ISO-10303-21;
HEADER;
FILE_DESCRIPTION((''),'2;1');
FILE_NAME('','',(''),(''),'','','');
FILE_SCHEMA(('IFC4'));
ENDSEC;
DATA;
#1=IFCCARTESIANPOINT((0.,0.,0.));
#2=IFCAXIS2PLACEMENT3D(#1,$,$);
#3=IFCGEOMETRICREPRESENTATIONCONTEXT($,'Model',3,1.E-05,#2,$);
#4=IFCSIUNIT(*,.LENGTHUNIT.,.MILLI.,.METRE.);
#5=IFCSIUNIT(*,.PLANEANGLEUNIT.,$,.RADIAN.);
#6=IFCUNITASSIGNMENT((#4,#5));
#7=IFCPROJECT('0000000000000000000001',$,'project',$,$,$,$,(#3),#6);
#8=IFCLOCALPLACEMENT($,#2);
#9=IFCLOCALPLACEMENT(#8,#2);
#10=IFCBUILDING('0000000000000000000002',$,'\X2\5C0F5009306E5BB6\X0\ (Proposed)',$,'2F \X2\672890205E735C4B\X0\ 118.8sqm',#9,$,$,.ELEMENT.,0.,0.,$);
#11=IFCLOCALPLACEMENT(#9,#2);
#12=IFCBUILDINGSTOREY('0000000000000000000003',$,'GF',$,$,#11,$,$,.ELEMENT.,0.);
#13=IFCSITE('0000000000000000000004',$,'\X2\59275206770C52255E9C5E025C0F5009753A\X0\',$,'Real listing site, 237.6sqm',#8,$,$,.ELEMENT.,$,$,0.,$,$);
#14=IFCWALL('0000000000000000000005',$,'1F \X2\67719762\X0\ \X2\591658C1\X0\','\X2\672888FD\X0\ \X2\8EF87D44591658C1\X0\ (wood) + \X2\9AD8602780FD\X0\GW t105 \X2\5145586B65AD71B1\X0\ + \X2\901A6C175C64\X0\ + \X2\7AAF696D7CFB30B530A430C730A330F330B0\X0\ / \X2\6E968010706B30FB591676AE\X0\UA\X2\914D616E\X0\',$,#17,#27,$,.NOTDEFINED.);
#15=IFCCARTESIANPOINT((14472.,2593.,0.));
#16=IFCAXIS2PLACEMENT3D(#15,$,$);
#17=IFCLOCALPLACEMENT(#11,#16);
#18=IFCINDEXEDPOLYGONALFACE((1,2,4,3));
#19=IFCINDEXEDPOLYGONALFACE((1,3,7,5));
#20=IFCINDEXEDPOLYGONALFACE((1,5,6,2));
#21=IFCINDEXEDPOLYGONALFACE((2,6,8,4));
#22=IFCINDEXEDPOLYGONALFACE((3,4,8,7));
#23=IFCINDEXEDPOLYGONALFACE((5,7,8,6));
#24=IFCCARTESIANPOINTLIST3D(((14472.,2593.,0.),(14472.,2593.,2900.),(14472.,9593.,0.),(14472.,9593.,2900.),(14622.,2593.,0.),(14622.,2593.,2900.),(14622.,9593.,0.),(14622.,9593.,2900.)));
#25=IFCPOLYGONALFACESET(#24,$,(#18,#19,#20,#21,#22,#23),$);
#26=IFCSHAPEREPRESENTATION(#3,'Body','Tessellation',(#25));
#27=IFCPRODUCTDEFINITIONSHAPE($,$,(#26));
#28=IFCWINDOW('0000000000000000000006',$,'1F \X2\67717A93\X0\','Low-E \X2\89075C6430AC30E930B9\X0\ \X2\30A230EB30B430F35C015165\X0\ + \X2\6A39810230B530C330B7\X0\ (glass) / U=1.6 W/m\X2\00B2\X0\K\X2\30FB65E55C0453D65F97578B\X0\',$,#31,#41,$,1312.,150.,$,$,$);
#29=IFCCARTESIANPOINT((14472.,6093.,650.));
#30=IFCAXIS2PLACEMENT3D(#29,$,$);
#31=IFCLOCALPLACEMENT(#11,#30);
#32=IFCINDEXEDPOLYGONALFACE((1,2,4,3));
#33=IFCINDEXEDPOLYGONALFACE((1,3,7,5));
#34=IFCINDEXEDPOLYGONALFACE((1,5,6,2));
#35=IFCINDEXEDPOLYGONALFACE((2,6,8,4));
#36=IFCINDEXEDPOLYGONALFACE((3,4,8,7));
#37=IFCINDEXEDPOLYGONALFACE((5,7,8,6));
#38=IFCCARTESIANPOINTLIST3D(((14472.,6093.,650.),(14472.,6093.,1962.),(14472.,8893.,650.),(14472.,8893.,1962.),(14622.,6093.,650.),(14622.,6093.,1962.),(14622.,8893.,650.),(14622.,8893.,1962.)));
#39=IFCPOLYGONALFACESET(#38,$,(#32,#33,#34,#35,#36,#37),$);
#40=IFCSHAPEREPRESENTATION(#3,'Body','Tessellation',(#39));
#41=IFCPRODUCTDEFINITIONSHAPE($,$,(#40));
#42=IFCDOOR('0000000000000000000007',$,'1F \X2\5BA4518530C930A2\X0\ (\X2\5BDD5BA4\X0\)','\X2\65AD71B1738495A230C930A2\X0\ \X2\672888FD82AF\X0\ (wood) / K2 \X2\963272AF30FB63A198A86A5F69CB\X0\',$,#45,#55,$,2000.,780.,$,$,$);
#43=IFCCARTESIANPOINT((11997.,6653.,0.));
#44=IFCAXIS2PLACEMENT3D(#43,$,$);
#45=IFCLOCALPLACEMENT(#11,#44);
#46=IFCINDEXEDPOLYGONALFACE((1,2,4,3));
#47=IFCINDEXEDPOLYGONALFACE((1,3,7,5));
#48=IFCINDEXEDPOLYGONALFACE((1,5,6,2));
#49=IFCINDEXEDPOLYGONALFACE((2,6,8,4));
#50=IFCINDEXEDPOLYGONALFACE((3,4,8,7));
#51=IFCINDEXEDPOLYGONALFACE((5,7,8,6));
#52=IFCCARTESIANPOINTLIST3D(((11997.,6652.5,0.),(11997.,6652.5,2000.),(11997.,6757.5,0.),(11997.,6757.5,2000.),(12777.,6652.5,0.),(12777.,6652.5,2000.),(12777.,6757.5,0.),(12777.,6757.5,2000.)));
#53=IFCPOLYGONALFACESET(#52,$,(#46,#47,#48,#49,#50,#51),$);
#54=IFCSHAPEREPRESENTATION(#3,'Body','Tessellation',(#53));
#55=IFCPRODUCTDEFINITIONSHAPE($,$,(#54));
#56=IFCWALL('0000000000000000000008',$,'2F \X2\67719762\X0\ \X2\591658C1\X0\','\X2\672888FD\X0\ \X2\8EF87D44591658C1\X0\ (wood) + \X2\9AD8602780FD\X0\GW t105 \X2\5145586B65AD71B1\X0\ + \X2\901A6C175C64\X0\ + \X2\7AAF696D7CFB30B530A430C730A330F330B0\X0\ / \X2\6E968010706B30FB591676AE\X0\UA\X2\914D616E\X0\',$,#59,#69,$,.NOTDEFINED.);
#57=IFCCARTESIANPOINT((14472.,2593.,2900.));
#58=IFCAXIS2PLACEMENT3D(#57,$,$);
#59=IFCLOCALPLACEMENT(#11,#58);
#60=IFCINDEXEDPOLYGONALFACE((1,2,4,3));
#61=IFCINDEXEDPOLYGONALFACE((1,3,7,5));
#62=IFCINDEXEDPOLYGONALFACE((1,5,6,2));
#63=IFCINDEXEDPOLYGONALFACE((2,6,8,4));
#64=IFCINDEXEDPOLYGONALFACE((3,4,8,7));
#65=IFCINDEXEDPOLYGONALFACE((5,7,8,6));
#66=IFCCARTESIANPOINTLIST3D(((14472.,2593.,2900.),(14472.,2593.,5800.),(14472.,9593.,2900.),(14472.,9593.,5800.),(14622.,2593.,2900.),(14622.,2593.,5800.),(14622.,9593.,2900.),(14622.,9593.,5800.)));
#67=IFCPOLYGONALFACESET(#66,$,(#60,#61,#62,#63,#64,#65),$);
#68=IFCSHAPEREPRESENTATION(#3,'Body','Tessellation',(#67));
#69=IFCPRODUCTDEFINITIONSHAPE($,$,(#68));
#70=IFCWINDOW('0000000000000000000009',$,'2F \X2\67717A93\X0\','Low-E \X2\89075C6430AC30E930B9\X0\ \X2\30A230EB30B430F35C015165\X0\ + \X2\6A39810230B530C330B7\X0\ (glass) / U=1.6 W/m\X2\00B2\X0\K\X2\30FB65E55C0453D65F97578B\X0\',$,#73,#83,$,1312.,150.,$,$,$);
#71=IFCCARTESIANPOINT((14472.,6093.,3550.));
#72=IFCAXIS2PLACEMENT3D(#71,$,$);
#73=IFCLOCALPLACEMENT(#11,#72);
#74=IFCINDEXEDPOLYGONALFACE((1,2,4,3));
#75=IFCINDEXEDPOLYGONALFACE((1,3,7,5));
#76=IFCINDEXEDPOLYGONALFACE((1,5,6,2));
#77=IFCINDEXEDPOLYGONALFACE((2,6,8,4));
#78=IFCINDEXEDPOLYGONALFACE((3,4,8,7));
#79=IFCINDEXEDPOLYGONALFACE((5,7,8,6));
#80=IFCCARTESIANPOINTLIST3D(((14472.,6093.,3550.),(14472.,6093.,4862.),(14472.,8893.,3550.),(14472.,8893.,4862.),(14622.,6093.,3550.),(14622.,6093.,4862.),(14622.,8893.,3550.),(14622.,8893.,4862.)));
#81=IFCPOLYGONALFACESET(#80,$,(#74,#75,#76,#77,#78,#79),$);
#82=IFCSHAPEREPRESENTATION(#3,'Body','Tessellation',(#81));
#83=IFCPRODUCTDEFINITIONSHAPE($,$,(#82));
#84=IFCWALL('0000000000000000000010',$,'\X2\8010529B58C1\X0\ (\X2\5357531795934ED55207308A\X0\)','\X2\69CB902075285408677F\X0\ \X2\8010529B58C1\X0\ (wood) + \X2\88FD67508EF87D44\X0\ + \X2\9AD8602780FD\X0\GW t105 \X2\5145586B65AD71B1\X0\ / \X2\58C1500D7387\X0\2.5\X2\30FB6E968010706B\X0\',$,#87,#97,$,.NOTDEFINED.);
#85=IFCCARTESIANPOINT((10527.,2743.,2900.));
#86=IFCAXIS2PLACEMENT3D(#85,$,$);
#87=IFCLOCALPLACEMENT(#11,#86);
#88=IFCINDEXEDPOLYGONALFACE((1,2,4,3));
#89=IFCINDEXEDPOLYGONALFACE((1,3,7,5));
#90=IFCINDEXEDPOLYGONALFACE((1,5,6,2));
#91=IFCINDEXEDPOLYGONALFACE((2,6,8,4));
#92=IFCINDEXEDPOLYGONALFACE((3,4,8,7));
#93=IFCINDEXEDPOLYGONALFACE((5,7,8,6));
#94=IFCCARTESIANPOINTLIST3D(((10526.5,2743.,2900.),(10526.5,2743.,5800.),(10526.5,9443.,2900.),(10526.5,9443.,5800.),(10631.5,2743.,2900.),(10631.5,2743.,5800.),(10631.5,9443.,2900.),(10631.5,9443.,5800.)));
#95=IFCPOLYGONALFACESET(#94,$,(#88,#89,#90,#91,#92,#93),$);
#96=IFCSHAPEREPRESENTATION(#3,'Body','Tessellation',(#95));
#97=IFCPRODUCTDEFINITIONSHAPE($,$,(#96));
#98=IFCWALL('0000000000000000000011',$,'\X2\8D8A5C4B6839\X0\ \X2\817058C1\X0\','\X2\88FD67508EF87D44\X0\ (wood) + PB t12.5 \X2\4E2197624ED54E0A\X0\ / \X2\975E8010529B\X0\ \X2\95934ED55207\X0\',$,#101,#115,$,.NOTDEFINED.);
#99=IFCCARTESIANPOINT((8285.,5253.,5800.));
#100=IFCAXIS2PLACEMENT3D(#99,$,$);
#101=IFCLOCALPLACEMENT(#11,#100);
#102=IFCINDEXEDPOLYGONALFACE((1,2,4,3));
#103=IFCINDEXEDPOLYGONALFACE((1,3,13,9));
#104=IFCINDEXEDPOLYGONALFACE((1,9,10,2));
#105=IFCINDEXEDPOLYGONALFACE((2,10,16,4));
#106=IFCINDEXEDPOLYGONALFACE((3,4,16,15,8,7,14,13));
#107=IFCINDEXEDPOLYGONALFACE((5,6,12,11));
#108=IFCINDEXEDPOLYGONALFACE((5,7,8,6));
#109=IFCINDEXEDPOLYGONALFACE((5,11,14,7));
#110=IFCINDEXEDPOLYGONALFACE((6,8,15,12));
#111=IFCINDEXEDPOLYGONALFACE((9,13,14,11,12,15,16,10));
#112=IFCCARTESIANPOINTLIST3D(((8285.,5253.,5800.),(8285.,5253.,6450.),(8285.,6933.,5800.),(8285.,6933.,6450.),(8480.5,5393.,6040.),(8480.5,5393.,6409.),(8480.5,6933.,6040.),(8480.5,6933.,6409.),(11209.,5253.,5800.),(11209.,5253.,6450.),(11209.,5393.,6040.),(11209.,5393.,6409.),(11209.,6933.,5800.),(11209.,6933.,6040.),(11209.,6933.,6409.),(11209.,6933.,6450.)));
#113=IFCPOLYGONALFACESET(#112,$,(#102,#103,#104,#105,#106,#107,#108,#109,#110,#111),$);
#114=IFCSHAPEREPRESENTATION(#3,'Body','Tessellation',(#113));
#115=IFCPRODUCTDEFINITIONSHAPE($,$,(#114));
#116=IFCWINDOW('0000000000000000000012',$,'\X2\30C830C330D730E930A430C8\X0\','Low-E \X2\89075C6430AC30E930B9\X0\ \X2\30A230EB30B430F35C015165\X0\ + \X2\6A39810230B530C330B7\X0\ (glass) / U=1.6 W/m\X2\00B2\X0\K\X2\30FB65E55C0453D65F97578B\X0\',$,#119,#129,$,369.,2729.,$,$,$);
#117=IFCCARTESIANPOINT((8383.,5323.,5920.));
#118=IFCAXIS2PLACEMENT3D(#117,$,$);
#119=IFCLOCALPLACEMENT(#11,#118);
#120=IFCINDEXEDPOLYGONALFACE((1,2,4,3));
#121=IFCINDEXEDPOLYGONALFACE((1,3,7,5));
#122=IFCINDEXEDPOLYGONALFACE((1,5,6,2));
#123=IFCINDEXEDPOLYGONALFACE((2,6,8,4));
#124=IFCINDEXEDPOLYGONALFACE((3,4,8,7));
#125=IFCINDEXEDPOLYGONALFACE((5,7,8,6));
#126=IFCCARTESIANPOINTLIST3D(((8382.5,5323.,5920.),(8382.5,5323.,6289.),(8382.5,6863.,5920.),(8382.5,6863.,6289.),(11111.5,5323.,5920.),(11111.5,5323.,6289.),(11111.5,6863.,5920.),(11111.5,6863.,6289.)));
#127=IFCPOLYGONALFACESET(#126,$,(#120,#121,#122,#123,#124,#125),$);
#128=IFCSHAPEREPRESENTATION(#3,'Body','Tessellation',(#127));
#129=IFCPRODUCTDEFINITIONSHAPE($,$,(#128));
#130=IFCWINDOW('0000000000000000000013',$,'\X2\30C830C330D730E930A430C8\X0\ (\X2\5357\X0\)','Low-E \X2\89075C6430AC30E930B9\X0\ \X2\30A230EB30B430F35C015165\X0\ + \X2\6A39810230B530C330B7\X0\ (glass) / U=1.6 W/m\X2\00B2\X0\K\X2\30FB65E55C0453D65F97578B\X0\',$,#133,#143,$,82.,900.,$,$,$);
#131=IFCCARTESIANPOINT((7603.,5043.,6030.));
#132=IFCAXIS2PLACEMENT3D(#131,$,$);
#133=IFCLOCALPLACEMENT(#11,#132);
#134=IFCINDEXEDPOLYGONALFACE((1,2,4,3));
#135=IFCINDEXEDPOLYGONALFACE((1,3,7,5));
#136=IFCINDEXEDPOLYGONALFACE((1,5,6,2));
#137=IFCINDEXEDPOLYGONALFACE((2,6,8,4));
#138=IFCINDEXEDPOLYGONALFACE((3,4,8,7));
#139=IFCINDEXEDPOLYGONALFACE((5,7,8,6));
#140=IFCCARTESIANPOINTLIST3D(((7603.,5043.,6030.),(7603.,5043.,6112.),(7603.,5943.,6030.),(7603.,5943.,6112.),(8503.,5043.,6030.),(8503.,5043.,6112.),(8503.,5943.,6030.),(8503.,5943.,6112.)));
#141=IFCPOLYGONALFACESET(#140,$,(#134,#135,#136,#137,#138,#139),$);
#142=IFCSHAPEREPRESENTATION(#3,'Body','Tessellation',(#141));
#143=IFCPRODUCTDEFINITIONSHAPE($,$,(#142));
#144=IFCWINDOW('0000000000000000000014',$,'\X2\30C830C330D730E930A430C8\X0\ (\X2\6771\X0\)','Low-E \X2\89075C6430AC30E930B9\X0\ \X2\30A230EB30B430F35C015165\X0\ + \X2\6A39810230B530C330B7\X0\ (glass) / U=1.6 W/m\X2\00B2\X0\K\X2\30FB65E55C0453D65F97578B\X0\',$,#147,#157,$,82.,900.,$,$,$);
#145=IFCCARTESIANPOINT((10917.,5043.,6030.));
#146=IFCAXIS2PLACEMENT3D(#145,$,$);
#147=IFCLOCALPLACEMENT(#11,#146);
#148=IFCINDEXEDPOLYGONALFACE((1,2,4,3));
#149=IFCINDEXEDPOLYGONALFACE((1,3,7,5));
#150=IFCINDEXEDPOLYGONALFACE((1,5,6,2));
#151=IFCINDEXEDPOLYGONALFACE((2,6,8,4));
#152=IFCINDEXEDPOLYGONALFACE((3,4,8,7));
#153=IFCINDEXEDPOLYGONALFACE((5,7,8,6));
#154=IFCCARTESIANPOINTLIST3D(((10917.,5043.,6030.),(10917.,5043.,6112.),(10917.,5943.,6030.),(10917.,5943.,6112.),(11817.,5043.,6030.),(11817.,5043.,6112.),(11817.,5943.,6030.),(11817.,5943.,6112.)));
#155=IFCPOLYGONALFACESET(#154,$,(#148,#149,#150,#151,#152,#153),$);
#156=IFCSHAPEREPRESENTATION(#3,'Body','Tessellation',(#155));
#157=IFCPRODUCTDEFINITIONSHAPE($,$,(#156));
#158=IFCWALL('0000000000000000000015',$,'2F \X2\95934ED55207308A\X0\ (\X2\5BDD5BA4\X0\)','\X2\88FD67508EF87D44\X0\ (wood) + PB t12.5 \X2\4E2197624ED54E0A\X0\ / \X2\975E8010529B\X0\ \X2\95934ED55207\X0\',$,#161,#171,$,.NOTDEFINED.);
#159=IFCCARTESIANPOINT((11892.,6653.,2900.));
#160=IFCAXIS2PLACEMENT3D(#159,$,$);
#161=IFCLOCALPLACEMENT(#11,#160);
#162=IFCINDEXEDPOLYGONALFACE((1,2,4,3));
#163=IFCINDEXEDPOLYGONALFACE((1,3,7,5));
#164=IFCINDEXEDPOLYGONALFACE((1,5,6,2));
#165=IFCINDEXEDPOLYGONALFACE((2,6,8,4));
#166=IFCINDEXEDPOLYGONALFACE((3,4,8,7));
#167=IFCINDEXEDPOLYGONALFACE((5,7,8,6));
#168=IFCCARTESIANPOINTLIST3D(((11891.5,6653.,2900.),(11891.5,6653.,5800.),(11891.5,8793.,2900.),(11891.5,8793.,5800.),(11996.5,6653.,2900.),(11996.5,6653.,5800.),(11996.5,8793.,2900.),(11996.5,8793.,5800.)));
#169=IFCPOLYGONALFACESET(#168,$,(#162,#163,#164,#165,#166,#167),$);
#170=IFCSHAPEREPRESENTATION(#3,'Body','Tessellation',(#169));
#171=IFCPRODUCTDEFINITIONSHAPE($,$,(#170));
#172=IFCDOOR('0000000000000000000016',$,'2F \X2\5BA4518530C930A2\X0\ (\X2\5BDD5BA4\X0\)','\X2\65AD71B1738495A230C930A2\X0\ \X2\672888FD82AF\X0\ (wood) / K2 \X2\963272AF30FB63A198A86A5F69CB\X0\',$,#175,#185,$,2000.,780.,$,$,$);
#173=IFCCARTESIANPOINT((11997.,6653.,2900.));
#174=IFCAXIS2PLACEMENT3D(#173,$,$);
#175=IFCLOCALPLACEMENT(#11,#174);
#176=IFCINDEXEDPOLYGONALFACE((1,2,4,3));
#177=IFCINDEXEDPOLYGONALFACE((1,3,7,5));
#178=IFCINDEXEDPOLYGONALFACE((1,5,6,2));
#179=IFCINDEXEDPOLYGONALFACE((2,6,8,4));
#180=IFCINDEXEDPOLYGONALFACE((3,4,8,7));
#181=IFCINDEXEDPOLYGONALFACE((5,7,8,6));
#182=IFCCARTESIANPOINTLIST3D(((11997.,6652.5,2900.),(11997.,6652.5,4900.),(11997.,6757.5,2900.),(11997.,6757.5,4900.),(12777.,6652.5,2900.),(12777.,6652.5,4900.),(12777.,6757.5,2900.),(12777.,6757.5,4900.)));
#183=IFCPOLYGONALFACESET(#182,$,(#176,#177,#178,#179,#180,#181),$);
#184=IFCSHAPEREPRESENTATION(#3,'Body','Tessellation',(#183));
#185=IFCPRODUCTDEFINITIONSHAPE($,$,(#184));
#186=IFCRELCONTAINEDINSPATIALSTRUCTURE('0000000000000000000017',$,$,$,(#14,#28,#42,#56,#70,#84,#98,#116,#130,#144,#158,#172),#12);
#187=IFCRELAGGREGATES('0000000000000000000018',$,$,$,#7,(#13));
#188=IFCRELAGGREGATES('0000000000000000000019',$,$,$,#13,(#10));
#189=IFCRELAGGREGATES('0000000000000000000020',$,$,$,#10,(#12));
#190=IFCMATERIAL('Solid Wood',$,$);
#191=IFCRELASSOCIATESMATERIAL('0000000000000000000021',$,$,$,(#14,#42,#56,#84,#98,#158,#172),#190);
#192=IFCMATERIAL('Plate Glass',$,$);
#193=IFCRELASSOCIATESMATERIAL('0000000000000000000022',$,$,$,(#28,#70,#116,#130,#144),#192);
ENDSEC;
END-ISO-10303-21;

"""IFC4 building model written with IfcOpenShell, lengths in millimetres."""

from ifc_helpers import new_model, si_unit, frame, frame_2d, origin, place, context, project, spatial, rectangle, extrude, material, element, fill, save


model = new_model("IFC4")

# Units and contexts
model_context = context("Model", 3, precision=1e-05, world=origin())
ifc_project = project(units=[si_unit("LENGTHUNIT", "METRE", prefix="MILLI"), si_unit("PLANEANGLEUNIT", "RADIAN")], contexts=[model_context])

# Site, building, storey
site_placement = place(None, origin())
site = spatial("IfcSite", under=ifc_project, at=site_placement, Name="大分県別府市小倉町", ObjectType="Real listing site, 237.6sqm", CompositionType="ELEMENT", RefElevation=0.0)
building_placement = place(site_placement, origin())
building = spatial("IfcBuilding", under=site, at=building_placement, Name="小倉の家 (Proposed)", ObjectType="2F 木造平屋 118.8sqm", CompositionType="ELEMENT", ElevationOfRefHeight=0.0, ElevationOfTerrain=0.0)
storey_placement = place(building_placement, origin())
storey = spatial("IfcBuildingStorey", under=building, at=storey_placement, Name="GF", CompositionType="ELEMENT", Elevation=0.0)

# Wall, opening, window
ifc_material_1 = material(Name="Solid Wood")
wall_1_placement = place(storey_placement, frame((14472.0, 2593.0, 0.0)))
wall_1 = element("IfcWall", 1, at=wall_1_placement, inside=storey, material=ifc_material_1, Name="1F 東面 外壁", Description="木製 軸組外壁 (wood) + 高性能GW t105 充填断熱 + 通気層 + 窯業系サイディング / 準耐火・外皮UA配慮", PredefinedType="NOTDEFINED", context=model_context, shape_type="SweptSolid", body=[
    extrude(rectangle(XDim=150.0, YDim=7000.0, at=frame_2d((75.0, 3500.0))), frame((14472.0, 2593.0, 0.0)), (0.0, 0.0, 1.0), 2900.0),
])
opening_1_placement = place(storey_placement, frame((14472.0, 6093.0, 650.0)))
opening_1 = element("IfcOpeningElement", 2, at=opening_1_placement, cuts=wall_1, PredefinedType="NOTDEFINED", context=model_context, shape_type="SweptSolid", body=[
    extrude(rectangle(XDim=150.0, YDim=2800.0, at=frame_2d((75.0, 1400.0))), frame((14472.0, 6093.0, 650.0)), (0.0, 0.0, 1.0), 1312.0),
])
ifc_material_2 = material(Name="Plate Glass")
window_1_placement = place(storey_placement, frame((14472.0, 6093.0, 650.0)))
window_1 = element("IfcWindow", 3, at=window_1_placement, inside=storey, material=ifc_material_2, Name="1F 東窓", Description="Low-E 複層ガラス アルゴン封入 + 樹脂サッシ (glass) / U=1.6 W/m²K・日射取得型", OverallHeight=1312.0, OverallWidth=150.0, context=model_context, shape_type="SweptSolid", body=[
    extrude(rectangle(XDim=150.0, YDim=2800.0, at=frame_2d((75.0, 1400.0))), frame((14472.0, 6093.0, 650.0)), (0.0, 0.0, 1.0), 1312.0),
])
fill(opening_1, window_1)

# Door
door_1_placement = place(storey_placement, frame((11997.0, 6653.0, 0.0)))
element("IfcDoor", 4, at=door_1_placement, inside=storey, material=ifc_material_1, Name="1F 室内ドア (寝室)", Description="断熱玄関ドア 木製芯 (wood) / K2 防犯・採風機構", OverallHeight=2000.0, OverallWidth=780.0, context=model_context, shape_type="SweptSolid", body=[
    extrude(rectangle(XDim=780.0, YDim=105.0, at=frame_2d((390.0, 52.0))), frame((11997.0, 6653.0, 0.0)), (0.0, 0.0, 1.0), 2000.0),
])

# Wall, opening, window
wall_2_placement = place(storey_placement, frame((14472.0, 2593.0, 2900.0)))
wall_2 = element("IfcWall", 5, at=wall_2_placement, inside=storey, material=ifc_material_1, Name="2F 東面 外壁", Description="木製 軸組外壁 (wood) + 高性能GW t105 充填断熱 + 通気層 + 窯業系サイディング / 準耐火・外皮UA配慮", PredefinedType="NOTDEFINED", context=model_context, shape_type="SweptSolid", body=[
    extrude(rectangle(XDim=150.0, YDim=7000.0, at=frame_2d((75.0, 3500.0))), frame((14472.0, 2593.0, 2900.0)), (0.0, 0.0, 1.0), 2900.0),
])
opening_2_placement = place(storey_placement, frame((14472.0, 6093.0, 3550.0)))
opening_2 = element("IfcOpeningElement", 6, at=opening_2_placement, cuts=wall_2, PredefinedType="NOTDEFINED", context=model_context, shape_type="SweptSolid", body=[
    extrude(rectangle(XDim=150.0, YDim=2800.0, at=frame_2d((75.0, 1400.0))), frame((14472.0, 6093.0, 3550.0)), (0.0, 0.0, 1.0), 1312.0),
])
window_2_placement = place(storey_placement, frame((14472.0, 6093.0, 3550.0)))
window_2 = element("IfcWindow", 7, at=window_2_placement, inside=storey, material=ifc_material_2, Name="2F 東窓", Description="Low-E 複層ガラス アルゴン封入 + 樹脂サッシ (glass) / U=1.6 W/m²K・日射取得型", OverallHeight=1312.0, OverallWidth=150.0, context=model_context, shape_type="SweptSolid", body=[
    extrude(rectangle(XDim=150.0, YDim=2800.0, at=frame_2d((75.0, 1400.0))), frame((14472.0, 6093.0, 3550.0)), (0.0, 0.0, 1.0), 1312.0),
])
fill(opening_2, window_2)

# Wall
wall_3_placement = place(storey_placement, frame((10527.0, 2743.0, 2900.0)))
element("IfcWall", 8, at=wall_3_placement, inside=storey, material=ifc_material_1, Name="耐力壁 (南北間仕切り)", Description="構造用合板 耐力壁 (wood) + 製材軸組 + 高性能GW t105 充填断熱 / 壁倍率2.5・準耐火", PredefinedType="NOTDEFINED", context=model_context, shape_type="SweptSolid", body=[
    extrude(rectangle(XDim=105.0, YDim=6700.0, at=frame_2d((52.0, 3350.0))), frame((10527.0, 2743.0, 2900.0)), (0.0, 0.0, 1.0), 2900.0),
])

# Wall, openings, windows
wall_4_placement = place(storey_placement, frame((8285.0, 5253.0, 5800.0)))
wall_4 = element("IfcWall", 9, at=wall_4_placement, inside=storey, material=ifc_material_1, Name="越屋根 腰壁", Description="製材軸組 (wood) + PB t12.5 両面仕上 / 非耐力 間仕切", PredefinedType="NOTDEFINED", context=model_context, shape_type="SweptSolid", body=[
    extrude(rectangle(XDim=2924.0, YDim=1680.0, at=frame_2d((1462.0, 840.0))), frame((8285.0, 5253.0, 5800.0)), (0.0, 0.0, 1.0), 650.0),
])
opening_3_placement = place(storey_placement, frame((8383.0, 5323.0, 5920.0)))
opening_3 = element("IfcOpeningElement", 10, at=opening_3_placement, cuts=wall_4, PredefinedType="NOTDEFINED", context=model_context, shape_type="SweptSolid", body=[
    extrude(rectangle(XDim=2729.0, YDim=1540.0, at=frame_2d((1364.0, 770.0))), frame((8383.0, 5323.0, 5920.0)), (0.0, 0.0, 1.0), 369.0),
])
opening_4_placement = place(storey_placement, frame((7603.0, 5043.0, 6030.0)))
opening_4 = element("IfcOpeningElement", 11, at=opening_4_placement, cuts=wall_4, PredefinedType="NOTDEFINED", context=model_context, shape_type="SweptSolid", body=[
    extrude(rectangle(XDim=900.0, YDim=900.0, at=frame_2d((450.0, 450.0))), frame((7603.0, 5043.0, 6030.0)), (0.0, 0.0, 1.0), 82.0),
])
opening_5_placement = place(storey_placement, frame((10917.0, 5043.0, 6030.0)))
opening_5 = element("IfcOpeningElement", 12, at=opening_5_placement, cuts=wall_4, PredefinedType="NOTDEFINED", context=model_context, shape_type="SweptSolid", body=[
    extrude(rectangle(XDim=900.0, YDim=900.0, at=frame_2d((450.0, 450.0))), frame((10917.0, 5043.0, 6030.0)), (0.0, 0.0, 1.0), 82.0),
])
window_3_placement = place(storey_placement, frame((8383.0, 5323.0, 5920.0)))
window_3 = element("IfcWindow", 13, at=window_3_placement, inside=storey, material=ifc_material_2, Name="トップライト", Description="Low-E 複層ガラス アルゴン封入 + 樹脂サッシ (glass) / U=1.6 W/m²K・日射取得型", OverallHeight=369.0, OverallWidth=2729.0, context=model_context, shape_type="SweptSolid", body=[
    extrude(rectangle(XDim=2729.0, YDim=1540.0, at=frame_2d((1364.0, 770.0))), frame((8383.0, 5323.0, 5920.0)), (0.0, 0.0, 1.0), 369.0),
])
fill(opening_3, window_3)
window_4_placement = place(storey_placement, frame((7603.0, 5043.0, 6030.0)))
window_4 = element("IfcWindow", 14, at=window_4_placement, inside=storey, material=ifc_material_2, Name="トップライト (南)", Description="Low-E 複層ガラス アルゴン封入 + 樹脂サッシ (glass) / U=1.6 W/m²K・日射取得型", OverallHeight=82.0, OverallWidth=900.0, context=model_context, shape_type="SweptSolid", body=[
    extrude(rectangle(XDim=900.0, YDim=900.0, at=frame_2d((450.0, 450.0))), frame((7603.0, 5043.0, 6030.0)), (0.0, 0.0, 1.0), 82.0),
])
fill(opening_4, window_4)
window_5_placement = place(storey_placement, frame((10917.0, 5043.0, 6030.0)))
window_5 = element("IfcWindow", 15, at=window_5_placement, inside=storey, material=ifc_material_2, Name="トップライト (東)", Description="Low-E 複層ガラス アルゴン封入 + 樹脂サッシ (glass) / U=1.6 W/m²K・日射取得型", OverallHeight=82.0, OverallWidth=900.0, context=model_context, shape_type="SweptSolid", body=[
    extrude(rectangle(XDim=900.0, YDim=900.0, at=frame_2d((450.0, 450.0))), frame((10917.0, 5043.0, 6030.0)), (0.0, 0.0, 1.0), 82.0),
])
fill(opening_5, window_5)

# Wall
wall_5_placement = place(storey_placement, frame((11892.0, 6653.0, 2900.0)))
element("IfcWall", 16, at=wall_5_placement, inside=storey, material=ifc_material_1, Name="2F 間仕切り (寝室)", Description="製材軸組 (wood) + PB t12.5 両面仕上 / 非耐力 間仕切", PredefinedType="NOTDEFINED", context=model_context, shape_type="SweptSolid", body=[
    extrude(rectangle(XDim=105.0, YDim=2140.0, at=frame_2d((52.0, 1070.0))), frame((11892.0, 6653.0, 2900.0)), (0.0, 0.0, 1.0), 2900.0),
])

# Door
door_2_placement = place(storey_placement, frame((11997.0, 6653.0, 2900.0)))
element("IfcDoor", 17, at=door_2_placement, inside=storey, material=ifc_material_1, Name="2F 室内ドア (寝室)", Description="断熱玄関ドア 木製芯 (wood) / K2 防犯・採風機構", OverallHeight=2000.0, OverallWidth=780.0, context=model_context, shape_type="SweptSolid", body=[
    extrude(rectangle(XDim=780.0, YDim=105.0, at=frame_2d((390.0, 52.0))), frame((11997.0, 6653.0, 2900.0)), (0.0, 0.0, 1.0), 2000.0),
])

save(model, "model.ifc")
